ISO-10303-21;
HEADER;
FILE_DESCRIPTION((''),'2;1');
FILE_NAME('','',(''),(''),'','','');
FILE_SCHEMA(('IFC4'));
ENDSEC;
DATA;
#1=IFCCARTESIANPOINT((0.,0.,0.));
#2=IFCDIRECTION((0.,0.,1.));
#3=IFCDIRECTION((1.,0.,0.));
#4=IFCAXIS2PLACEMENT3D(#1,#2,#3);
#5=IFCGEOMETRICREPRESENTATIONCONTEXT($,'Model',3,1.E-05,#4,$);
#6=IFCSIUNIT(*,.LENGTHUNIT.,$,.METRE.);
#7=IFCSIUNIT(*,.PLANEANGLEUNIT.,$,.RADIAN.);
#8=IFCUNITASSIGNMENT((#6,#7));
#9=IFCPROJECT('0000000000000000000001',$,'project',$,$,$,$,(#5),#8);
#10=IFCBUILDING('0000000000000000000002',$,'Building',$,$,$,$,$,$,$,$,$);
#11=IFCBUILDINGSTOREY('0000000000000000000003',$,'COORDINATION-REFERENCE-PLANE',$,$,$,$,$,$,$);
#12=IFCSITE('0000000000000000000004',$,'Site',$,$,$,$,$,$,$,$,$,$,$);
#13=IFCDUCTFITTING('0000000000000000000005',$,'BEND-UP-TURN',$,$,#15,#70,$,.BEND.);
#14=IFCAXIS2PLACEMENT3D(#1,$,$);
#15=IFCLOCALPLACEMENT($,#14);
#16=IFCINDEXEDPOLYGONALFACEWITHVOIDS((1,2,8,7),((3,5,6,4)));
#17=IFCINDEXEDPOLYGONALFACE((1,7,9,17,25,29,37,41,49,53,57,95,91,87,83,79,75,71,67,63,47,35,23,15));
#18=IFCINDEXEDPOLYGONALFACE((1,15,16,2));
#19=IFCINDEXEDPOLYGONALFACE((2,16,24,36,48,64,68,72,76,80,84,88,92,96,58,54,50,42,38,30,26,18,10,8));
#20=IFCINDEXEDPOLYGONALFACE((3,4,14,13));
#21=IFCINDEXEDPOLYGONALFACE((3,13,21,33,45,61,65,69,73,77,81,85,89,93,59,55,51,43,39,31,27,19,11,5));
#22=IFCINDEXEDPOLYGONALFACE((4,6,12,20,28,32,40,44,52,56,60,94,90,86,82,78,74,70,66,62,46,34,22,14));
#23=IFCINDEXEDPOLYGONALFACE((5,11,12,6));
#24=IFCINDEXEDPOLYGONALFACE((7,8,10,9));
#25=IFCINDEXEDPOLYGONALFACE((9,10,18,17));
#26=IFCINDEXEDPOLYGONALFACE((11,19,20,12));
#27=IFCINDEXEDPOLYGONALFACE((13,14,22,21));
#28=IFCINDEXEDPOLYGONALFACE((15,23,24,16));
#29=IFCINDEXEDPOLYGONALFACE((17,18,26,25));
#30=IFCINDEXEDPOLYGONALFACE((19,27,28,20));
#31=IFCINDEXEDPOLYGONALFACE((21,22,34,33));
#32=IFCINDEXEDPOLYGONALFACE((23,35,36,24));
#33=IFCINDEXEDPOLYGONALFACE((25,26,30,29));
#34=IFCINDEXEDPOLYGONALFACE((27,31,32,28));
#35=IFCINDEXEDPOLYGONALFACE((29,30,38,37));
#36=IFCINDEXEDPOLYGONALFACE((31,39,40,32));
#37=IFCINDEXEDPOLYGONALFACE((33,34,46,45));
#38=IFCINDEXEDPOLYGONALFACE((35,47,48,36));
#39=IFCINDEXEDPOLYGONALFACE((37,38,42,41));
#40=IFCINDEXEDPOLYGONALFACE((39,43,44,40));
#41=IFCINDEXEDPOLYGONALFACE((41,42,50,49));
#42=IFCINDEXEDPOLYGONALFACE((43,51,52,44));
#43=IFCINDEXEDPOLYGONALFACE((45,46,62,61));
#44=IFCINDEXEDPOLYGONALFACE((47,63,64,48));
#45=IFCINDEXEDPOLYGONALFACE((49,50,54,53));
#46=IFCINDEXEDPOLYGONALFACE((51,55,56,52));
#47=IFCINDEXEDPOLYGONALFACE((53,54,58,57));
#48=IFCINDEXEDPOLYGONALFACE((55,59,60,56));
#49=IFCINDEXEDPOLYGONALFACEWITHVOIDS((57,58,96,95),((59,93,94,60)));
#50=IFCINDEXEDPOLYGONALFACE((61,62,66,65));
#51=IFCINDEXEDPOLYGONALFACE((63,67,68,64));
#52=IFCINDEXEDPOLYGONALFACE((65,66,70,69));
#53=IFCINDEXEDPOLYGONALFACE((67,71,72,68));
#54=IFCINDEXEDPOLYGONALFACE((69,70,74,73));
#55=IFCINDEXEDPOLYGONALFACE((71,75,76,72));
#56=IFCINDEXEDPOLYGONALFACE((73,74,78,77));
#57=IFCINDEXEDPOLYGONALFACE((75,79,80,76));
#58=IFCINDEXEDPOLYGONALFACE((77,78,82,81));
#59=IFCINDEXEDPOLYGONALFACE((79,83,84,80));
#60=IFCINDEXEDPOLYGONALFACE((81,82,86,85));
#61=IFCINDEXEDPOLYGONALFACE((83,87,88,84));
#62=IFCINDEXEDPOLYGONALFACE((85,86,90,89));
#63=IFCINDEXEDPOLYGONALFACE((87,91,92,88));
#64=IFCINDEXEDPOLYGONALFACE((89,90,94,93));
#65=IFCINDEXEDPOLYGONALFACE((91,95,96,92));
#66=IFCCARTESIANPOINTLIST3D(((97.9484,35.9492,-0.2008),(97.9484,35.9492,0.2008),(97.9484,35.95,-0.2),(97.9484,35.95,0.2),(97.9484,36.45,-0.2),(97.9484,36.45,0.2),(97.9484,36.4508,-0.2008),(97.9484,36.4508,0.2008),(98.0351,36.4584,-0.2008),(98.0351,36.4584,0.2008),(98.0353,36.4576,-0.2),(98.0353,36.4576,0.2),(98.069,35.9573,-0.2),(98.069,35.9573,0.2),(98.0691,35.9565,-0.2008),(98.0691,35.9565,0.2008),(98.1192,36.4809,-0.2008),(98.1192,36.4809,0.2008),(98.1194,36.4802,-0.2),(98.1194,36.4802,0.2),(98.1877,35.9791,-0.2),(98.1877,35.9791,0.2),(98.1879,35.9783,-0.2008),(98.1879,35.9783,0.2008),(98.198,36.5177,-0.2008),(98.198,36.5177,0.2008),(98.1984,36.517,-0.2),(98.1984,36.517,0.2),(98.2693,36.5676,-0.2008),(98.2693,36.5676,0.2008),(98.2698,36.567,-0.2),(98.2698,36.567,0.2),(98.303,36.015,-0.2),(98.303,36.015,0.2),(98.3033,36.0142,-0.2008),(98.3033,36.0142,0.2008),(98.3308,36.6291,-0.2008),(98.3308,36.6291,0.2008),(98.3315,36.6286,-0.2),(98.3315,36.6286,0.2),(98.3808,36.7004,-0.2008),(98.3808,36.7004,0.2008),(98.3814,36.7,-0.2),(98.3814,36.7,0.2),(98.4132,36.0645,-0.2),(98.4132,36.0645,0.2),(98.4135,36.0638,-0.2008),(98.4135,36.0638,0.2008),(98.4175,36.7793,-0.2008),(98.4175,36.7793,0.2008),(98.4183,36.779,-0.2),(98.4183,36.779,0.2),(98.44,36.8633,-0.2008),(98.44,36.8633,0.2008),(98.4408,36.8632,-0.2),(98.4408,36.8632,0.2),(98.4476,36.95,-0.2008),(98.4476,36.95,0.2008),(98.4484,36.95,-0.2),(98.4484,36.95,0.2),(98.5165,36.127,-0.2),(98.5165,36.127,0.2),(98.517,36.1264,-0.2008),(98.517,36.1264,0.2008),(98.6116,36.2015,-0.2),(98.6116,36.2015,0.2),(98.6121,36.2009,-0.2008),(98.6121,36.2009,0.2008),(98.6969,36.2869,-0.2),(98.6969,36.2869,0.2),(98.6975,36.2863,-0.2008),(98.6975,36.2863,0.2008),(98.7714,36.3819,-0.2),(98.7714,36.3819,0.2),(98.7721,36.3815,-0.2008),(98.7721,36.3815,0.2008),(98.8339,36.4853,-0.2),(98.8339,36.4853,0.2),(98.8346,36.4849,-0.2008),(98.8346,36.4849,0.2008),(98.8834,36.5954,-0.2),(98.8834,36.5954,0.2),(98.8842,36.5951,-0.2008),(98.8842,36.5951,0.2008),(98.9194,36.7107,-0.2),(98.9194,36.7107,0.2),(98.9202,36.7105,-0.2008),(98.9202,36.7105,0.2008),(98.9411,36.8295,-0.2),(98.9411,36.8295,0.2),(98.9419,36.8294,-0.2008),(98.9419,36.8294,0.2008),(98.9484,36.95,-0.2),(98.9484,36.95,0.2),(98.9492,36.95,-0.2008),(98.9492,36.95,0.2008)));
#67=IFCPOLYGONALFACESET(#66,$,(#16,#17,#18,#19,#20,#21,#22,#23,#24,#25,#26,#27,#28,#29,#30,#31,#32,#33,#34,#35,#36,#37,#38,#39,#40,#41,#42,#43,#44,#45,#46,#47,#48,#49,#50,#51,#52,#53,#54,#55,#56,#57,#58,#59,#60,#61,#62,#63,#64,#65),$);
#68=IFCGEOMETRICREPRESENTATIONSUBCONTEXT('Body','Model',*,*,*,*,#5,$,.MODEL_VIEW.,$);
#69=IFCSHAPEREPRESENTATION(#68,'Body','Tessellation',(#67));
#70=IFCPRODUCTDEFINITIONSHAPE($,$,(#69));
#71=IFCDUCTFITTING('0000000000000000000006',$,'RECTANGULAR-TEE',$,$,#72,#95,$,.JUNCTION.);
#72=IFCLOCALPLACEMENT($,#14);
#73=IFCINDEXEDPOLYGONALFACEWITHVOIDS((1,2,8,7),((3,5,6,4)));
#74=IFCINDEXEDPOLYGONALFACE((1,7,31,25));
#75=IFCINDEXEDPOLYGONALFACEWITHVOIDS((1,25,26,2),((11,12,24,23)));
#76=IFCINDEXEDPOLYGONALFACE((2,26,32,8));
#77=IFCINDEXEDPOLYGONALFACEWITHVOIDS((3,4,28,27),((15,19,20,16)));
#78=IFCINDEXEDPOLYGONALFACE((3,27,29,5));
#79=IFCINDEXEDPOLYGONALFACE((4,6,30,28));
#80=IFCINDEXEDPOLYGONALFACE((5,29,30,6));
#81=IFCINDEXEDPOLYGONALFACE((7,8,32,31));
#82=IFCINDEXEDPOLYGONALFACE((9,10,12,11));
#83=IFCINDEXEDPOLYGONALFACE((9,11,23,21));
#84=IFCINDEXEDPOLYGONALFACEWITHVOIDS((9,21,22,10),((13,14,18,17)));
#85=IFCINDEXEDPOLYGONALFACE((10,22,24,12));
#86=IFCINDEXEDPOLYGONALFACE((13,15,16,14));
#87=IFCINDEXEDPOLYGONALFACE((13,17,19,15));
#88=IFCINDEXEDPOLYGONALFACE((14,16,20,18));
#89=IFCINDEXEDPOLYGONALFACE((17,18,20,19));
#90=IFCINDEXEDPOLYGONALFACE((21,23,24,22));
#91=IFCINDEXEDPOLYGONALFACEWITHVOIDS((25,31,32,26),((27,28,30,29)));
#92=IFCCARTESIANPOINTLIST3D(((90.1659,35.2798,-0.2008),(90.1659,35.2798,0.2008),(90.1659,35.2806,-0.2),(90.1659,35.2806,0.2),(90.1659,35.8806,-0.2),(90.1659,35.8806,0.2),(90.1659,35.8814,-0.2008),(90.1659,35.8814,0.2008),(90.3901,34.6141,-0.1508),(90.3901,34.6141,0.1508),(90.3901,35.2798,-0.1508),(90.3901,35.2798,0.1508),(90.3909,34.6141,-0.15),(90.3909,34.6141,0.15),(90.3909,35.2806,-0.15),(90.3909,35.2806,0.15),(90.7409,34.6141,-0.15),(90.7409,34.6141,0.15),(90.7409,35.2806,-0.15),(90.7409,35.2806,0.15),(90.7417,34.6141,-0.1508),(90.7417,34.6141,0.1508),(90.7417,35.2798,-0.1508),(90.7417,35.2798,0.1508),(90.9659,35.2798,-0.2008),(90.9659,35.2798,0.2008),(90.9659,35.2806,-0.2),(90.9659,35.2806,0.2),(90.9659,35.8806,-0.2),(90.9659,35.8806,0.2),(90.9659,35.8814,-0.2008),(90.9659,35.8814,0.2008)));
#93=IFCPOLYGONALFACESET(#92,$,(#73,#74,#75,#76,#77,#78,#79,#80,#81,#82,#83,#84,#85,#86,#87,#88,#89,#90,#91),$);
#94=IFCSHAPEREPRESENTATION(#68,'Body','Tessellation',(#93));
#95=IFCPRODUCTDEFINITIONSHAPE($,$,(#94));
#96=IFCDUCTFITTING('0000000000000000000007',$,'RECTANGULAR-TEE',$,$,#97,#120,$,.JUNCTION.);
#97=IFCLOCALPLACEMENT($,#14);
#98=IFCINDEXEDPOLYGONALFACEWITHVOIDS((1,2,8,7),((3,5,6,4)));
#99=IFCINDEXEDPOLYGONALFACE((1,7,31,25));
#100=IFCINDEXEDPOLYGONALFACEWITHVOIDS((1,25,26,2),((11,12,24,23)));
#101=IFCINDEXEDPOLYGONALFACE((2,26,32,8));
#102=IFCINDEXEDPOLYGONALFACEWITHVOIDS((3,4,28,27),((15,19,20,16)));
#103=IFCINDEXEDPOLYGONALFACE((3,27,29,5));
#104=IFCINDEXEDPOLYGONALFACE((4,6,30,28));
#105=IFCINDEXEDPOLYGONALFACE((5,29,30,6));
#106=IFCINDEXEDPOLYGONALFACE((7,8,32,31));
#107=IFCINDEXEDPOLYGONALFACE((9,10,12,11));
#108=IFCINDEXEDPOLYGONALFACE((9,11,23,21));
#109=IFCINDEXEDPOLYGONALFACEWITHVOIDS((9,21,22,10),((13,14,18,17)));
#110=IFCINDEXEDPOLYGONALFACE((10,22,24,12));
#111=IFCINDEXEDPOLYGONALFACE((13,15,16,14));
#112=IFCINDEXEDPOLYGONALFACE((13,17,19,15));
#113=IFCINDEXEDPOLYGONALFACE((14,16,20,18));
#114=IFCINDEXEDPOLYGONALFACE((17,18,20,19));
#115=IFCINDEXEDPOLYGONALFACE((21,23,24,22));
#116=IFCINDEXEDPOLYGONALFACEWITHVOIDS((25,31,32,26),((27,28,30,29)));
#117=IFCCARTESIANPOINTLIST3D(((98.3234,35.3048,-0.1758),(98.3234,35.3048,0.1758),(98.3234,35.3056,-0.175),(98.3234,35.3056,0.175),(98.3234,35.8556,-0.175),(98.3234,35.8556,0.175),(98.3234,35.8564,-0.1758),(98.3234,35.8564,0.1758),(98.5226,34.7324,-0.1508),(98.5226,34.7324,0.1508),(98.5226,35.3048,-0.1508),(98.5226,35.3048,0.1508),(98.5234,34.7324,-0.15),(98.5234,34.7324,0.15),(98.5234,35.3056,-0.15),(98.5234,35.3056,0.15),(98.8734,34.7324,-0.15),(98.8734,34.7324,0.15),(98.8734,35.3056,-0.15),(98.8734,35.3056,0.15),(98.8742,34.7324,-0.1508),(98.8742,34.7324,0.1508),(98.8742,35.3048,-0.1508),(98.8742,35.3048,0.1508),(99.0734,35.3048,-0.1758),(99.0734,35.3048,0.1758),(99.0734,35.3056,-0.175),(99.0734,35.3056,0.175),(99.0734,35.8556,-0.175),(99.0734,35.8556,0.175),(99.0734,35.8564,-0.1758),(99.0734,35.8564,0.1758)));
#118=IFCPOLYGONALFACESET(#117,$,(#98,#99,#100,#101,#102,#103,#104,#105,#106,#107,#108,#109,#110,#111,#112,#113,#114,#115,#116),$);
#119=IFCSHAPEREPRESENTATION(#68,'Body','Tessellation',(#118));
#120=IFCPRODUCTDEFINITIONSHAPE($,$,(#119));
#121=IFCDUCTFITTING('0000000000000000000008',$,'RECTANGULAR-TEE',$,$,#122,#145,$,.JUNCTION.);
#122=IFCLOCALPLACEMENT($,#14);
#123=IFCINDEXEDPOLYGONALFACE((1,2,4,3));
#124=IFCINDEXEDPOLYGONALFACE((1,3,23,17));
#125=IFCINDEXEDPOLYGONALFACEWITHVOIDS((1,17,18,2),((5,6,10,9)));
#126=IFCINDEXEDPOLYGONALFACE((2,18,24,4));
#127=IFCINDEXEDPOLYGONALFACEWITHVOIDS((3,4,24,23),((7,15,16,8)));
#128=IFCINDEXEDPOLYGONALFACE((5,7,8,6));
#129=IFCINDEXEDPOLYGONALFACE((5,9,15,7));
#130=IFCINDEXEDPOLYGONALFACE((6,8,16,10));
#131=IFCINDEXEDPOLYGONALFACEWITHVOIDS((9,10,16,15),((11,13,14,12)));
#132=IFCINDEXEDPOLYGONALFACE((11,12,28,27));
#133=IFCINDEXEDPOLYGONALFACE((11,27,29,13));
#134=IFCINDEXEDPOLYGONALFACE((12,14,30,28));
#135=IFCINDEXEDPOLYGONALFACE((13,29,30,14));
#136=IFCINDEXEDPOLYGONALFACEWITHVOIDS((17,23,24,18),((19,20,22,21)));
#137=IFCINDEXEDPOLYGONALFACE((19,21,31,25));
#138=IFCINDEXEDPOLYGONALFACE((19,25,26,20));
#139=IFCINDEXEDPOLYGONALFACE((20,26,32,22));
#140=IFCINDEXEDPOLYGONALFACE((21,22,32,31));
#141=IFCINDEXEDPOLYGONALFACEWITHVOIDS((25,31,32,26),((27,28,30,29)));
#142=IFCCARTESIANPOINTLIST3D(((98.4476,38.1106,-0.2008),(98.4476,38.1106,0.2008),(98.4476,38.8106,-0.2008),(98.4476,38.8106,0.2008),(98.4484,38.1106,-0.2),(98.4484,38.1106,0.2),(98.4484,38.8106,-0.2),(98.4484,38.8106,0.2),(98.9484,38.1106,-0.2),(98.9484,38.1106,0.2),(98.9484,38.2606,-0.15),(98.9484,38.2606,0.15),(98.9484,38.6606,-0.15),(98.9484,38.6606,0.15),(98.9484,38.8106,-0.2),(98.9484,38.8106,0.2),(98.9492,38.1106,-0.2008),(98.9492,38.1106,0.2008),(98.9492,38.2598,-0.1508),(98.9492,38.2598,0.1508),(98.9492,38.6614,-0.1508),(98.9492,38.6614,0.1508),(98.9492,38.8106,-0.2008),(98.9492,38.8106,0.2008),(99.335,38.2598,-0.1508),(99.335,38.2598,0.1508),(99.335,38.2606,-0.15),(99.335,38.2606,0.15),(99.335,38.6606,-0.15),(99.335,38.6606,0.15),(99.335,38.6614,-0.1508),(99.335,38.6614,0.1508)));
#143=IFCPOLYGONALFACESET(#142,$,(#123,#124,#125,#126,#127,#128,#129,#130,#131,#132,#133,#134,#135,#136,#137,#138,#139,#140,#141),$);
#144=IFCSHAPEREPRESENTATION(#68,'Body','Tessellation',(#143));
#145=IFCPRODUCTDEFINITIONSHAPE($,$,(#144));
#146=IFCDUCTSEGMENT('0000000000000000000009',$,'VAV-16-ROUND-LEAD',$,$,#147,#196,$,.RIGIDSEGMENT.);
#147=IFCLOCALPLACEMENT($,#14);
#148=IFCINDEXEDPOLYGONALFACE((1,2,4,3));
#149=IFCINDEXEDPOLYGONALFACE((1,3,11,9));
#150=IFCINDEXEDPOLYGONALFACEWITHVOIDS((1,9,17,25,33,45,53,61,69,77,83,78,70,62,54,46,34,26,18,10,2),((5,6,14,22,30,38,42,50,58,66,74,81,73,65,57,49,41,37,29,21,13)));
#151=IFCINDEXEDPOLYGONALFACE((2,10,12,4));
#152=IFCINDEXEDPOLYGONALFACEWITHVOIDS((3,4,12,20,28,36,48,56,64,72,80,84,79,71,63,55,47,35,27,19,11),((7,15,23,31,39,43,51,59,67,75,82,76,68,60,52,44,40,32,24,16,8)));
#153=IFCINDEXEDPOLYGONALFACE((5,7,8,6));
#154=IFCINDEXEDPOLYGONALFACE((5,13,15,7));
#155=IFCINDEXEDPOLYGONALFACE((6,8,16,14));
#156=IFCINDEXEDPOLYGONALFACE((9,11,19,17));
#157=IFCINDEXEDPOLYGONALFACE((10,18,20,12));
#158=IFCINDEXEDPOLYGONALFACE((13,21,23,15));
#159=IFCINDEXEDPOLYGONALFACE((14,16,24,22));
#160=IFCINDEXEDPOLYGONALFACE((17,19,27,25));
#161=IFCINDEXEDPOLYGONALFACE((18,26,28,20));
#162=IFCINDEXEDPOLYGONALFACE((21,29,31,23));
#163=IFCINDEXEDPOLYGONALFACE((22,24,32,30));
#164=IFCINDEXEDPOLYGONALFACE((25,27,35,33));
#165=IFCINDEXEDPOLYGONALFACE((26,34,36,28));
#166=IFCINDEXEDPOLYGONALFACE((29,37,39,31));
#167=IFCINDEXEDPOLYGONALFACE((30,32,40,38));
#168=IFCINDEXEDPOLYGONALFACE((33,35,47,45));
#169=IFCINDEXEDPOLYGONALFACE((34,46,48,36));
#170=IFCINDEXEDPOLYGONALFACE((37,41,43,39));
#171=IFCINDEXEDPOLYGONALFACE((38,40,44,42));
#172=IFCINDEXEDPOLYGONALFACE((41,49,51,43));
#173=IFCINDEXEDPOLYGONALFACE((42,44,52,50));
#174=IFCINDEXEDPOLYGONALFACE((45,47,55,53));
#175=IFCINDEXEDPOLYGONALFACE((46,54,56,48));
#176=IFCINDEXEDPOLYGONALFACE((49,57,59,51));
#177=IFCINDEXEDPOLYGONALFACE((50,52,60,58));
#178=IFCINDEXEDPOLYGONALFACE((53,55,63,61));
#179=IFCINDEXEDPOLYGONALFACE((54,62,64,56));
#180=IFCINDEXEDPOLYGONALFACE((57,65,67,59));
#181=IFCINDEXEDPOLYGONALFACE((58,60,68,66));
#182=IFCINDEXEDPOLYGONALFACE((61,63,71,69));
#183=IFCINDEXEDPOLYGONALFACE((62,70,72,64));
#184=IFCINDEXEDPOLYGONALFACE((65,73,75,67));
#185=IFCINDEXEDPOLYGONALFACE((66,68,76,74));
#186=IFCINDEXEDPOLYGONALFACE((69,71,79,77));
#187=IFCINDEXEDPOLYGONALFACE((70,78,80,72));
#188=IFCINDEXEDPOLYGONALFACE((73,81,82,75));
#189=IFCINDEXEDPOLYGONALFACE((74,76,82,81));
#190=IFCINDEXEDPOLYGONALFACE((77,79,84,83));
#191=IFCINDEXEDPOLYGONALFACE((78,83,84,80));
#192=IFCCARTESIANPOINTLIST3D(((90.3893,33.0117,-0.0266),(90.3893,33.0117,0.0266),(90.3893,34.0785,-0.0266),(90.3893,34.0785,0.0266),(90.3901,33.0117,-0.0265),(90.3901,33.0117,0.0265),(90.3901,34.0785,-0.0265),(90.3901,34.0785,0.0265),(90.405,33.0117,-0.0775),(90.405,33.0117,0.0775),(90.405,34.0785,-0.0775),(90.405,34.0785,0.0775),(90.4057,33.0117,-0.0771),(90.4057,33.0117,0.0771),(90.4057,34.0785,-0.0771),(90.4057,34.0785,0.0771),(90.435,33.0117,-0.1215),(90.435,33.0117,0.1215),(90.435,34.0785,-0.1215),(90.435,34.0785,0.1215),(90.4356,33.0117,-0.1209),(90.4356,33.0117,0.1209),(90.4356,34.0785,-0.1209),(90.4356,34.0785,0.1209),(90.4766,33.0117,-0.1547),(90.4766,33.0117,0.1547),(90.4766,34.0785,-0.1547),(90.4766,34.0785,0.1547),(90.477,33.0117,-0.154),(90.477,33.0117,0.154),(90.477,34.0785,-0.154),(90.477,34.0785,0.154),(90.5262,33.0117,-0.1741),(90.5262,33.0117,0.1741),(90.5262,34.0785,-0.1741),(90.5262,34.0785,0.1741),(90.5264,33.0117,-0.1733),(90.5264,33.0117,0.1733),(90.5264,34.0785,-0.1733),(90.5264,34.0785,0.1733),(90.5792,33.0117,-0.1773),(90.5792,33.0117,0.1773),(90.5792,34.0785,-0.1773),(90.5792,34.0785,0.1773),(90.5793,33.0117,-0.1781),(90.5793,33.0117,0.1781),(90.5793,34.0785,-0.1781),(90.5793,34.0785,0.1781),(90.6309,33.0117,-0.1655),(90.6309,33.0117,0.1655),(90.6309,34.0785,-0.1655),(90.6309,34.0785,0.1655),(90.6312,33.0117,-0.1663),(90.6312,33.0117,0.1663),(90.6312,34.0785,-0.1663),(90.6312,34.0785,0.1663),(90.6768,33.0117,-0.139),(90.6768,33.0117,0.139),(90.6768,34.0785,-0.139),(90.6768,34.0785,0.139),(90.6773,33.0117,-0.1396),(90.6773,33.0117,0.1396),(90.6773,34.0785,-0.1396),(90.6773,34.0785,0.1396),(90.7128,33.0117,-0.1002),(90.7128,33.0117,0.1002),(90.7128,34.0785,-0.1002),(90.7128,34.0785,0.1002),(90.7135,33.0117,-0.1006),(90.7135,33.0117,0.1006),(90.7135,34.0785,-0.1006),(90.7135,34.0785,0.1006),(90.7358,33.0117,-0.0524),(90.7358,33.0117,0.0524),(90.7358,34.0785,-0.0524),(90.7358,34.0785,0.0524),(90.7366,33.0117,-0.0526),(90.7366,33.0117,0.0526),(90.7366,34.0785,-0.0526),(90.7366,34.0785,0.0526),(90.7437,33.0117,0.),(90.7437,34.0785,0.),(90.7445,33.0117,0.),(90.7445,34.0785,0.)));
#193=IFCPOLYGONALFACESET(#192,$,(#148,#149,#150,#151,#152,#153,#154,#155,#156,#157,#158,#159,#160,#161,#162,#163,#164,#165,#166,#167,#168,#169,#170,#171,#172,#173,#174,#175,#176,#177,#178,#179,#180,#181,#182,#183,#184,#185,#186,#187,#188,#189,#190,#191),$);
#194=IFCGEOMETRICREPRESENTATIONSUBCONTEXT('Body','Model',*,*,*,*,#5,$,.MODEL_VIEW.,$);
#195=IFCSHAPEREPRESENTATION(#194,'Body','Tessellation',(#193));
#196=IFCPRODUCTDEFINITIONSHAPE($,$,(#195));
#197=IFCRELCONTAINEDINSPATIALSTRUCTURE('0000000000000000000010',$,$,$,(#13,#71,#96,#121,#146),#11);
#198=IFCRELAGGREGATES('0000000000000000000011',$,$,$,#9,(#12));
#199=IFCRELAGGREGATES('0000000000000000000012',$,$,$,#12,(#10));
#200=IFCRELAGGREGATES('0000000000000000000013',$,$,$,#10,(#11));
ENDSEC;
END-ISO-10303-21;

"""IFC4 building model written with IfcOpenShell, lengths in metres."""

from ifc_helpers import new_model, entity, si_unit, frame, origin, origin_with_axes, place, context, subcontext, project, spatial, rectangle, hollow_circle, extrude, boolean, element, save


model = new_model("IFC4")

# Units and contexts
model_context = context("Model", 3, precision=1e-05, world=origin_with_axes())
body_context_1 = subcontext(model_context, "Body", "Model", "MODEL_VIEW")
body_context_2 = subcontext(model_context, "Body", "Model", "MODEL_VIEW")
ifc_project = project(units=[si_unit("LENGTHUNIT", "METRE"), si_unit("PLANEANGLEUNIT", "RADIAN")], contexts=[model_context])

# Site, building, storey
site = spatial("IfcSite", under=ifc_project, Name="Site")
building = spatial("IfcBuilding", under=site, Name="Building")
storey = spatial("IfcBuildingStorey", under=building, Name="COORDINATION-REFERENCE-PLANE")

# Duct fittings
duct_fitting_1_placement = place(None, frame((97.9484, 36.95, 0.0), z_axis=(0.0, 0.0, 1.0), x_axis=(0.0, -1.0, 0.0)))
cartesian_point_1 = entity("IfcCartesianPoint", [0.0, 0.0, 0.0])
element("IfcDuctFitting", 1, at=duct_fitting_1_placement, inside=storey, Name="BEND-UP-TURN", PredefinedType="BEND", context=body_context_1, shape_type="SweptSolid", body=[
    entity("IfcRevolvedAreaSolid", entity("IfcRectangleHollowProfileDef", "AREA", None, entity("IfcAxis2Placement2D", entity("IfcCartesianPoint", [0.75, 0.0])), 0.5016, 0.4016, 0.0008), entity("IfcAxis2Placement3D", cartesian_point_1, entity("IfcDirection", [0.0, -1.0, 0.0]), entity("IfcDirection", [1.0, 0.0, 0.0])), entity("IfcAxis1Placement", cartesian_point_1, entity("IfcDirection", [0.0, 1.0, 0.0])), 1.570796),
])
duct_fitting_2_placement = place(None, frame((90.5659, 35.5806, 0.0), z_axis=(1.0, 0.0, 0.0), x_axis=(0.0, -1.0, 0.0)))
solid_1 = boolean("UNION", extrude(rectangle(XDim=0.6, YDim=0.4), frame((0.0, 0.0, -0.4), z_axis=(0.0, 0.0, 1.0), x_axis=(1.0, 0.0, 0.0)), (0.0, 0.0, 1.0), 0.8), extrude(rectangle(XDim=0.35, YDim=0.3), frame((0.0, 0.0, 0.0), z_axis=(1.0, 0.0, 0.0), x_axis=(0.0, 0.0, -1.0)), (0.0, 0.0, 1.0), 0.9665))
element("IfcDuctFitting", 2, at=duct_fitting_2_placement, inside=storey, Name="RECTANGULAR-TEE", PredefinedType="JUNCTION", context=body_context_1, shape_type="CSG", body=[
    boolean("DIFFERENCE", boolean("UNION", extrude(rectangle(XDim=0.6016, YDim=0.4016), frame((0.0, 0.0, -0.4), z_axis=(0.0, 0.0, 1.0), x_axis=(1.0, 0.0, 0.0)), (0.0, 0.0, 1.0), 0.8), extrude(rectangle(XDim=0.3516, YDim=0.3016), frame((0.0, 0.0, 0.0), z_axis=(1.0, 0.0, 0.0), x_axis=(0.0, 0.0, -1.0)), (0.0, 0.0, 1.0), 0.9665)), solid_1),
])
duct_fitting_3_placement = place(None, frame((98.6984, 35.5806, 0.0), z_axis=(1.0, 0.0, 0.0), x_axis=(0.0, -1.0, 0.0)))
solid_2 = boolean("UNION", extrude(rectangle(XDim=0.55, YDim=0.35), frame((0.0, 0.0, -0.375), z_axis=(0.0, 0.0, 1.0), x_axis=(1.0, 0.0, 0.0)), (0.0, 0.0, 1.0), 0.75), extrude(rectangle(XDim=0.35, YDim=0.3), frame((0.0, 0.0, 0.0), z_axis=(1.0, 0.0, 0.0), x_axis=(0.0, 0.0, -1.0)), (0.0, 0.0, 1.0), 0.8482))
element("IfcDuctFitting", 3, at=duct_fitting_3_placement, inside=storey, Name="RECTANGULAR-TEE", PredefinedType="JUNCTION", context=body_context_1, shape_type="CSG", body=[
    boolean("DIFFERENCE", boolean("UNION", extrude(rectangle(XDim=0.5516, YDim=0.3516), frame((0.0, 0.0, -0.375), z_axis=(0.0, 0.0, 1.0), x_axis=(1.0, 0.0, 0.0)), (0.0, 0.0, 1.0), 0.75), extrude(rectangle(XDim=0.3516, YDim=0.3016), frame((0.0, 0.0, 0.0), z_axis=(1.0, 0.0, 0.0), x_axis=(0.0, 0.0, -1.0)), (0.0, 0.0, 1.0), 0.8482)), solid_2),
])
duct_fitting_4_placement = place(None, frame((98.6984, 38.4606, 0.0), z_axis=(0.0, 1.0, 0.0), x_axis=(1.0, 0.0, 0.0)))
solid_3 = boolean("UNION", extrude(rectangle(XDim=0.5, YDim=0.4), frame((0.0, 0.0, -0.35), z_axis=(0.0, 0.0, 1.0), x_axis=(1.0, 0.0, 0.0)), (0.0, 0.0, 1.0), 0.7), extrude(rectangle(XDim=0.4, YDim=0.3), frame((0.0, 0.0, 0.0), z_axis=(1.0, 0.0, 0.0), x_axis=(0.0, 0.0, -1.0)), (0.0, 0.0, 1.0), 0.6366))
element("IfcDuctFitting", 4, at=duct_fitting_4_placement, inside=storey, Name="RECTANGULAR-TEE", PredefinedType="JUNCTION", context=body_context_1, shape_type="CSG", body=[
    boolean("DIFFERENCE", boolean("UNION", extrude(rectangle(XDim=0.5016, YDim=0.4016), frame((0.0, 0.0, -0.35), z_axis=(0.0, 0.0, 1.0), x_axis=(1.0, 0.0, 0.0)), (0.0, 0.0, 1.0), 0.7), extrude(rectangle(XDim=0.4016, YDim=0.3016), frame((0.0, 0.0, 0.0), z_axis=(1.0, 0.0, 0.0), x_axis=(0.0, 0.0, -1.0)), (0.0, 0.0, 1.0), 0.6366)), solid_3),
])

# Duct segment
for number, where, z_axis, x_axis, name in (
    (5, (90.5659, 34.0785, 0.0), (0.0, -1.0, 0.0), (1.0, 0.0, 0.0), "VAV-16-ROUND-LEAD"),
):
    element("IfcDuctSegment", number, at=place(None, frame(where, z_axis=z_axis, x_axis=x_axis)), inside=storey, Name=name, PredefinedType="RIGIDSEGMENT", context=body_context_2, shape_type="SweptSolid", body=[
        extrude(hollow_circle(Radius=0.1786, WallThickness=0.0008), origin(), (0.0, 0.0, 1.0), 1.0668),
    ])

save(model, "model.ifc")
